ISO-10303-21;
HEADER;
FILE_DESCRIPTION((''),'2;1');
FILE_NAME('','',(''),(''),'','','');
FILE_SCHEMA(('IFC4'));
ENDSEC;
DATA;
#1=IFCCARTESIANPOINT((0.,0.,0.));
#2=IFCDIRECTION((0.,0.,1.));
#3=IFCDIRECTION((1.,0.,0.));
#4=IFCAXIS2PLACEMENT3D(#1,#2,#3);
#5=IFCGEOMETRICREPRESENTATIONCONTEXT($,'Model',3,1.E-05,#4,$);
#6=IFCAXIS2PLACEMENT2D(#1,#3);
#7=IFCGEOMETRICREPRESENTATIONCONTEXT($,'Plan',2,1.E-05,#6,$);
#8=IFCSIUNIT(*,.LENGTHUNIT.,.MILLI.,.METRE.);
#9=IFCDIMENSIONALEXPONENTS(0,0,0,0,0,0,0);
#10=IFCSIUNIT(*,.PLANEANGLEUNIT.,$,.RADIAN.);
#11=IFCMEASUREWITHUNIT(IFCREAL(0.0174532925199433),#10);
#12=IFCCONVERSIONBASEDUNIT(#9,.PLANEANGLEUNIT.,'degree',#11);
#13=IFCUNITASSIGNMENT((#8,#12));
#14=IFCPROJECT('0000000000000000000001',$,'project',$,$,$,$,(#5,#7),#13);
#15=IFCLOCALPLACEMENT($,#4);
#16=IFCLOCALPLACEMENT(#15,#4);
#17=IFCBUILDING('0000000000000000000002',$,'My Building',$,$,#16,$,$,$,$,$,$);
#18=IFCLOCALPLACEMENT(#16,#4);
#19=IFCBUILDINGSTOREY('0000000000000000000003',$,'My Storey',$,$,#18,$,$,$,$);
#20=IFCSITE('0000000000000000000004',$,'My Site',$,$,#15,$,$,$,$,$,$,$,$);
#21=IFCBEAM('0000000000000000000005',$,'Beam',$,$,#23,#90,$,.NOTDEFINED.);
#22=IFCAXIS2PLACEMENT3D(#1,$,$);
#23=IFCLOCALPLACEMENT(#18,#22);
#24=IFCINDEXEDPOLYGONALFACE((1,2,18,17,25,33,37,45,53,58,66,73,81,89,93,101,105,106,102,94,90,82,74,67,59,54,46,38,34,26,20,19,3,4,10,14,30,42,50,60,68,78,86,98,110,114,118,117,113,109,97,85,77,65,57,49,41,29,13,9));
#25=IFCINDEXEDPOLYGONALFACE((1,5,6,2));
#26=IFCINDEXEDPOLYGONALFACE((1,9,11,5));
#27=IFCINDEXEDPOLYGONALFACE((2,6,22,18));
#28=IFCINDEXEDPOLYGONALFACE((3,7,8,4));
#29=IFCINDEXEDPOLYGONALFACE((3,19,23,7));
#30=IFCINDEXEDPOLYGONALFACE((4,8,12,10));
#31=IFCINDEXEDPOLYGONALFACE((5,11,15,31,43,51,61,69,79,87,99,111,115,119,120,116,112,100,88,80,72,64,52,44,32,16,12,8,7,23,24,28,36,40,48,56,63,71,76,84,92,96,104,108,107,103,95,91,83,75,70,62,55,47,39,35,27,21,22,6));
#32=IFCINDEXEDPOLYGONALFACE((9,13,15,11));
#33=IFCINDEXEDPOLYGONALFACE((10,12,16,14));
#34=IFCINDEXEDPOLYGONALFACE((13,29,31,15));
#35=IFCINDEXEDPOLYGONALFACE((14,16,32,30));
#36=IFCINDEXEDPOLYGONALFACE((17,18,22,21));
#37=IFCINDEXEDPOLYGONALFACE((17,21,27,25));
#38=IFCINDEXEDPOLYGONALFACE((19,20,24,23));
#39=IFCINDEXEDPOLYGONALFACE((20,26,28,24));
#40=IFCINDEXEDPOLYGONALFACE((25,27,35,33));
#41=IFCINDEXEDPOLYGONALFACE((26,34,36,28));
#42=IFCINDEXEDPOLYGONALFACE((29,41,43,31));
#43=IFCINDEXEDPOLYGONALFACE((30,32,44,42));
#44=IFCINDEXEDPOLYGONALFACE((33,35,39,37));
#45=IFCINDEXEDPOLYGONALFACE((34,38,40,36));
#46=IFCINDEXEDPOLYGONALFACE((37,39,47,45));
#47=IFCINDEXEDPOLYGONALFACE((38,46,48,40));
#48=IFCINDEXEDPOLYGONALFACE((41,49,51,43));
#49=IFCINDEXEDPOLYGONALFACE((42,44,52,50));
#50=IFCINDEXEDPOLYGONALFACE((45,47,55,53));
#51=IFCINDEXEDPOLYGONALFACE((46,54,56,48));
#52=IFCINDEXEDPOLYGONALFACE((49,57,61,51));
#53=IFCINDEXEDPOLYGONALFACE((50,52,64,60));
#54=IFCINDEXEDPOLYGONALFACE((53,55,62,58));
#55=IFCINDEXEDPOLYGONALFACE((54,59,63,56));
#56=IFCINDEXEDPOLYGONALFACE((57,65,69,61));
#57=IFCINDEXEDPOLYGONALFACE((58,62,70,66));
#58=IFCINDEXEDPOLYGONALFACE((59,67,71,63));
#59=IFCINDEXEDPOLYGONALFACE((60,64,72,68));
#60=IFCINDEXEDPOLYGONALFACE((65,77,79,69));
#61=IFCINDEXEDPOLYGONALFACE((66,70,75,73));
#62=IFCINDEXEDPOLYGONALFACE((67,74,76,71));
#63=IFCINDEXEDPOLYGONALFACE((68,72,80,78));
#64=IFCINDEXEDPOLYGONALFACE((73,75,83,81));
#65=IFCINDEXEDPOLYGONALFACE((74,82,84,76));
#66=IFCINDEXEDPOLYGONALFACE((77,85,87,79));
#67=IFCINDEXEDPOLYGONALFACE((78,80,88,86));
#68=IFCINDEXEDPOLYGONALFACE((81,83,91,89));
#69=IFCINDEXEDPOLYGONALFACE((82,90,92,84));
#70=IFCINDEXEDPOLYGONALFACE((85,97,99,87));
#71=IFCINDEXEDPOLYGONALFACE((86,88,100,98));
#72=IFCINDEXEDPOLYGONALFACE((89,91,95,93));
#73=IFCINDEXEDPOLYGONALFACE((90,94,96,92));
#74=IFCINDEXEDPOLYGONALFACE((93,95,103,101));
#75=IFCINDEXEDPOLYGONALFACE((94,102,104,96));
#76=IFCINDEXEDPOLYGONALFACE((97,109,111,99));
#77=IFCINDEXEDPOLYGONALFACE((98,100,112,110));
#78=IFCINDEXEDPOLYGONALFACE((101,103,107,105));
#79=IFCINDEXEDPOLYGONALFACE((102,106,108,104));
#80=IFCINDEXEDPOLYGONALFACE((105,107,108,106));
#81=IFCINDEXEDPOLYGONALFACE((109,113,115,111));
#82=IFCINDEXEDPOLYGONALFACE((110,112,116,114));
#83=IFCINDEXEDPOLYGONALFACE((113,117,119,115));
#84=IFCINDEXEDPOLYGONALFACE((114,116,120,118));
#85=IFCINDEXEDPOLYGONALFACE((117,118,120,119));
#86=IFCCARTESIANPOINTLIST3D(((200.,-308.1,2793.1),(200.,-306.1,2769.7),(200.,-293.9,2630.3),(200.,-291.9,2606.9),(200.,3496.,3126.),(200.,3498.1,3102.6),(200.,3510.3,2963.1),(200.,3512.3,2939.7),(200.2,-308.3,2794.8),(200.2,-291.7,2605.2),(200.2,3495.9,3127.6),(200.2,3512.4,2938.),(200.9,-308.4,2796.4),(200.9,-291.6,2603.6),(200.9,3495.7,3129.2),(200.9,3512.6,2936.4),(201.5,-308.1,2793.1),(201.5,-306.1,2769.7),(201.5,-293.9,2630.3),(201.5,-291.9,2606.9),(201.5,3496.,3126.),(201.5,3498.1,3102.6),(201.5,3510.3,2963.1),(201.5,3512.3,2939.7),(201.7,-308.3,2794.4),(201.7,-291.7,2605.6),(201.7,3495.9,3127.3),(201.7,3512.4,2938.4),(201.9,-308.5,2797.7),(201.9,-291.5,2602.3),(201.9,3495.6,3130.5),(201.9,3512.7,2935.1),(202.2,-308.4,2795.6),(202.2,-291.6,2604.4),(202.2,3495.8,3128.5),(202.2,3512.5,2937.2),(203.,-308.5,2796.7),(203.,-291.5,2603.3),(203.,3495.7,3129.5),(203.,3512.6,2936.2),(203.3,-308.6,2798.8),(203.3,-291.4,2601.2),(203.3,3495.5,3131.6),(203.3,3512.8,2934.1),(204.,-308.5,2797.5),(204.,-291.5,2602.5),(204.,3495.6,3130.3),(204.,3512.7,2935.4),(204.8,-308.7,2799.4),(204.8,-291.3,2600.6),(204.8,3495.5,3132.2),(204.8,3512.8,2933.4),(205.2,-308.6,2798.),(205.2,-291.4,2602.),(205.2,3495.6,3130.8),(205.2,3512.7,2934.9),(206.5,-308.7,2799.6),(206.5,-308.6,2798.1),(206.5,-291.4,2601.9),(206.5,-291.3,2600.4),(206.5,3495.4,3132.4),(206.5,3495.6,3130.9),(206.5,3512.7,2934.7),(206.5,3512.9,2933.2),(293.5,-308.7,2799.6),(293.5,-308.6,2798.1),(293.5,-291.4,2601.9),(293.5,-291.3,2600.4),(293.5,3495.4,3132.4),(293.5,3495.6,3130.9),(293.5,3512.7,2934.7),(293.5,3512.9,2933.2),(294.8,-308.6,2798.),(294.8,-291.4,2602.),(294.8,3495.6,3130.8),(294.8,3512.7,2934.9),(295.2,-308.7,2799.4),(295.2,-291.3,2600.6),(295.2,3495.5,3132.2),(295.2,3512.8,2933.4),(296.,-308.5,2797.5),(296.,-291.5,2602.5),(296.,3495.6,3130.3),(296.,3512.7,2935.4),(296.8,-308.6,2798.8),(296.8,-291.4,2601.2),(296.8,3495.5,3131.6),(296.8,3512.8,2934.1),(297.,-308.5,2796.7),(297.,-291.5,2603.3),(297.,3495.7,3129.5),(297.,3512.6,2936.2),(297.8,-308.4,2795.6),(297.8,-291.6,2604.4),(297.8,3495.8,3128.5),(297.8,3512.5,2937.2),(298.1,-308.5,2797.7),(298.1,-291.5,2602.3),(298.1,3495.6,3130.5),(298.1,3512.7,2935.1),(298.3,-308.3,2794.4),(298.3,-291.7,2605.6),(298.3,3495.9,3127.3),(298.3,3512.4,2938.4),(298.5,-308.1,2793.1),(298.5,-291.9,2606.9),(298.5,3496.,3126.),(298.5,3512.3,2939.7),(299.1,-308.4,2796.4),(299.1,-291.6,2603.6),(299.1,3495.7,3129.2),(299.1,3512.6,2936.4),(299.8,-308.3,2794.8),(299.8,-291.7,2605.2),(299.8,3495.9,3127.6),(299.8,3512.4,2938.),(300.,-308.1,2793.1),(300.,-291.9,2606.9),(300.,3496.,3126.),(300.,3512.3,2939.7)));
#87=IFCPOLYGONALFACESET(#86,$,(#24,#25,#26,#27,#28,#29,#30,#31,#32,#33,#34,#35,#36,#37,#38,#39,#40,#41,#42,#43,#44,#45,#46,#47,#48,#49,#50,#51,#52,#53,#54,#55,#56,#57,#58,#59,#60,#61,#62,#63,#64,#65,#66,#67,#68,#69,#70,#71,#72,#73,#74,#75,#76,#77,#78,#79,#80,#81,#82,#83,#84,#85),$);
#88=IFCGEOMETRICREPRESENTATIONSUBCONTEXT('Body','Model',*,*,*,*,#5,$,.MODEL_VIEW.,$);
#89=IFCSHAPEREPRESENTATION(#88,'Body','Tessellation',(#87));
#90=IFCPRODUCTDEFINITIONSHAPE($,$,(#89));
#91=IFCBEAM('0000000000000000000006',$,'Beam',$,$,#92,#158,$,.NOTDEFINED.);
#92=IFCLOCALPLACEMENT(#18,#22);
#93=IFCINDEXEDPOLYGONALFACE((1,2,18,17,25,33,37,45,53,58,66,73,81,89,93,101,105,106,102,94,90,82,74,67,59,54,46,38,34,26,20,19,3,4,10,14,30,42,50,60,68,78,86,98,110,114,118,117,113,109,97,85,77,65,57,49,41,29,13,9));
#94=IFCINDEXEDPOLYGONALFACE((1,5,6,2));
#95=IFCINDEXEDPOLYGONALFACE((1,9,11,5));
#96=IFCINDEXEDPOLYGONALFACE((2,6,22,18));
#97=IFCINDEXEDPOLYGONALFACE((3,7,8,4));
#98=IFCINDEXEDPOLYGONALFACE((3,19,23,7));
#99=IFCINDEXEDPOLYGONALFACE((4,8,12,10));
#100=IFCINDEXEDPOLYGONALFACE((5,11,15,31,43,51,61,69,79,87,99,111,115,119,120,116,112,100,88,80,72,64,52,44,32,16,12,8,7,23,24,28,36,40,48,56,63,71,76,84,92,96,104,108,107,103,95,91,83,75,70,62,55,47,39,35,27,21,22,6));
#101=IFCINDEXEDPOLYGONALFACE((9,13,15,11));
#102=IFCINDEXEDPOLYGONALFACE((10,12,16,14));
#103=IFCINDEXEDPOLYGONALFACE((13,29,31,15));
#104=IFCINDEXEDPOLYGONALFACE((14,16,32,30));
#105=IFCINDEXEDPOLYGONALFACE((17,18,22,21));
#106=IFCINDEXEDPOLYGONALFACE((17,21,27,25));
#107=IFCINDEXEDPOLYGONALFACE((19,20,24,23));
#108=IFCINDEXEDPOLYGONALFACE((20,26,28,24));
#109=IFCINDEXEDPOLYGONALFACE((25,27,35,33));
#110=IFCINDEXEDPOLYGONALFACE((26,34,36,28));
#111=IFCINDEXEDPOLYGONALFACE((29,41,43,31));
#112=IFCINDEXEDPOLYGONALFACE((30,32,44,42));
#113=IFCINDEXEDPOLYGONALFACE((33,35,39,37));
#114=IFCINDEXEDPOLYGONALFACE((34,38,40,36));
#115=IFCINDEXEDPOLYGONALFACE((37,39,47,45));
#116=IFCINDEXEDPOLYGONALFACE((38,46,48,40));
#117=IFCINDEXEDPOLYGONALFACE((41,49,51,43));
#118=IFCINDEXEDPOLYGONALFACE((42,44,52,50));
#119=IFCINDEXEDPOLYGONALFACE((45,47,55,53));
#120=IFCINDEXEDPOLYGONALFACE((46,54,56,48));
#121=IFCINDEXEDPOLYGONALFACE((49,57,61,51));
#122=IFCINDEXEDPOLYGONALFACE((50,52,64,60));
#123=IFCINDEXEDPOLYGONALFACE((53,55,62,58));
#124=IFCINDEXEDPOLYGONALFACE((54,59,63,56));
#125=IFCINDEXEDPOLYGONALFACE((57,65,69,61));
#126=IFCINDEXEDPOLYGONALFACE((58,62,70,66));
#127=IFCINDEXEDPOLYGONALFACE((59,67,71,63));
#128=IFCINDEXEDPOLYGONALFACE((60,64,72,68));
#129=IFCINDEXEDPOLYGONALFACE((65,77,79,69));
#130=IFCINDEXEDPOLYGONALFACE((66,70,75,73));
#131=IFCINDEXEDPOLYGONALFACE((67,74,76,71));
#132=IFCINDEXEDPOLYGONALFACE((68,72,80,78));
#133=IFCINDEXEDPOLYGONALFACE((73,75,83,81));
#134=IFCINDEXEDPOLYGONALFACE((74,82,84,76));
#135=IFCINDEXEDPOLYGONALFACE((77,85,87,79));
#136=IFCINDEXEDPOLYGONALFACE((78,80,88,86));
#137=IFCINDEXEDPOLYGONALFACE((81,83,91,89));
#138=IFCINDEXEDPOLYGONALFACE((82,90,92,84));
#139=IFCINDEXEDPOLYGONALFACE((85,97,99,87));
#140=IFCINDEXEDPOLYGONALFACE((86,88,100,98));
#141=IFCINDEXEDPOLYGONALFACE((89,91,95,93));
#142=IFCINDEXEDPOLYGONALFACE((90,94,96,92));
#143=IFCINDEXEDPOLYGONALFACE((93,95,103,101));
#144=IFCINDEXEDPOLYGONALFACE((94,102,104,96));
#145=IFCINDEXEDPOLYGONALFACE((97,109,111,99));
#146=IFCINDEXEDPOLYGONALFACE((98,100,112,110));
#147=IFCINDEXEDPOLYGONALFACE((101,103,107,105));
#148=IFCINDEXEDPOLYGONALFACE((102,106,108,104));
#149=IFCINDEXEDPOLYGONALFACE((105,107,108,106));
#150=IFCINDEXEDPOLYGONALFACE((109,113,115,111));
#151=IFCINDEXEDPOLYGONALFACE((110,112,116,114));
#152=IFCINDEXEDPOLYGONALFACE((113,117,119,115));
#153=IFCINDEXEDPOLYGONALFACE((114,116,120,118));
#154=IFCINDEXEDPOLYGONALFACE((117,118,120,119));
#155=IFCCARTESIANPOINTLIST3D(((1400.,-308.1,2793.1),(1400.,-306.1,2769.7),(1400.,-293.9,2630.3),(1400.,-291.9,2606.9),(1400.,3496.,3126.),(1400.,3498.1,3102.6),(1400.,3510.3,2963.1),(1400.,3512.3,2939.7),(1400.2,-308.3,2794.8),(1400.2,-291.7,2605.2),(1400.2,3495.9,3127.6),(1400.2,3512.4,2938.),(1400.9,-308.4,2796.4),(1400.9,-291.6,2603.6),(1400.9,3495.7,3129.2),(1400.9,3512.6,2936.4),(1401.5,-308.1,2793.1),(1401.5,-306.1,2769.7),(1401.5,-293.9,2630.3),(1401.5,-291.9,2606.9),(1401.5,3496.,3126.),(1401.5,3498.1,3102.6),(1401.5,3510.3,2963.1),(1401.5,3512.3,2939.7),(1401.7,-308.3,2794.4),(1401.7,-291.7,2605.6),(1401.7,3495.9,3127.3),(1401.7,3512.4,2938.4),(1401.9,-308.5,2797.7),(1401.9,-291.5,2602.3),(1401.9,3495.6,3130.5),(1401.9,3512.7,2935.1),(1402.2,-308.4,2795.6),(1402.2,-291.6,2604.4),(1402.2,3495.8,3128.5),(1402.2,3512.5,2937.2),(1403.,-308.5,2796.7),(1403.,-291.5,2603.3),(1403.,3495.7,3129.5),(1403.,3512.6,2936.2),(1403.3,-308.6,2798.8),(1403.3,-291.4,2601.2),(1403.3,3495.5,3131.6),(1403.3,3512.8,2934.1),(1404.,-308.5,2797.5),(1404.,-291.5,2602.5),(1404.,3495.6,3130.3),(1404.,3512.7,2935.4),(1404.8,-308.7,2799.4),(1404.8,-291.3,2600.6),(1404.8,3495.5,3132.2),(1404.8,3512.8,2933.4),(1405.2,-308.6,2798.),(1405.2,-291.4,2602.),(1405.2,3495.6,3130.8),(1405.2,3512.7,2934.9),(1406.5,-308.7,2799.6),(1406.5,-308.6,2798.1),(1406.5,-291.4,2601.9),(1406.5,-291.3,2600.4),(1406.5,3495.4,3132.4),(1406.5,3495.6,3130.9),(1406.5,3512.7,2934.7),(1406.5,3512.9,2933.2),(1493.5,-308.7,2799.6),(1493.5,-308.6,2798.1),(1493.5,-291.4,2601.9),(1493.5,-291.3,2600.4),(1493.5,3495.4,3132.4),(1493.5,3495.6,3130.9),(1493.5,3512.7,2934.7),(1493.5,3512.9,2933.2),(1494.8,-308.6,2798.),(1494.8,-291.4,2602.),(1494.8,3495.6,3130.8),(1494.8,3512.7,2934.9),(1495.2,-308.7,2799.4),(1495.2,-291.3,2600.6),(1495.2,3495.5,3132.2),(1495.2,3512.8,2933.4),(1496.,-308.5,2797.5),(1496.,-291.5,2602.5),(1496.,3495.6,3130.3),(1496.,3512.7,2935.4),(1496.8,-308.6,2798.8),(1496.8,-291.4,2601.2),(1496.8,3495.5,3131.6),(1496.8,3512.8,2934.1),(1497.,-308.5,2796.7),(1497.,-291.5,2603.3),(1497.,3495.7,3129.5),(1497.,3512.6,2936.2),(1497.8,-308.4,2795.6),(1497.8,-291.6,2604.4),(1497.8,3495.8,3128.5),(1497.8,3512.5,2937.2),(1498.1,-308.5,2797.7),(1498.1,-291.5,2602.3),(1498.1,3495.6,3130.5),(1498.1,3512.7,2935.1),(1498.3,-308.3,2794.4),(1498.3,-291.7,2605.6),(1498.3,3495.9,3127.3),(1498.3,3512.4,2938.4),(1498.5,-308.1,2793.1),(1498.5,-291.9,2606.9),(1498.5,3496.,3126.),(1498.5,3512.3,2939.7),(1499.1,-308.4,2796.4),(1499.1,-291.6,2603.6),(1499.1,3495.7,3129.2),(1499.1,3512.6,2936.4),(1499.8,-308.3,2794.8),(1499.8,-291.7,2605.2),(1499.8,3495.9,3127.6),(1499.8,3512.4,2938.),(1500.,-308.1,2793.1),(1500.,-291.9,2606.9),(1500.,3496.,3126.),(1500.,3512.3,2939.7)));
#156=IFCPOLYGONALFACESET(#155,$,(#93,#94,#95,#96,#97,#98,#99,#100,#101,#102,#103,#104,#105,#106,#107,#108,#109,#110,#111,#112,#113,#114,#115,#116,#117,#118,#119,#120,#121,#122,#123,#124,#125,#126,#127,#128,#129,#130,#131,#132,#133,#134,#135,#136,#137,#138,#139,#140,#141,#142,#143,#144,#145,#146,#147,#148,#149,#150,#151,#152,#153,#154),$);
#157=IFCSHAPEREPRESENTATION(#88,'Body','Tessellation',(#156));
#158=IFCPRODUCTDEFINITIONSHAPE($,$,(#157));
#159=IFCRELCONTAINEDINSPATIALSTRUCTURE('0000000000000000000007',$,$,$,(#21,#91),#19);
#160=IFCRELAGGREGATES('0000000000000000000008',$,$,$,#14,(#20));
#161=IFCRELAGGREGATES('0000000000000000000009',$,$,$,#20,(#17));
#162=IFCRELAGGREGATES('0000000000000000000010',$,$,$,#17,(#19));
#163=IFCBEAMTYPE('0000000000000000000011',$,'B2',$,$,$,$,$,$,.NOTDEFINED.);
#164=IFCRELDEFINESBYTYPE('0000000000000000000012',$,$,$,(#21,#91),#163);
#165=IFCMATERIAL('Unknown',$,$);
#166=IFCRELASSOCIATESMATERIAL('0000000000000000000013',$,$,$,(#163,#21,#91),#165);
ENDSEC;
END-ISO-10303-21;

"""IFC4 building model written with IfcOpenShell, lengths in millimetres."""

from ifc_helpers import new_model, entity, si_unit, converted_unit, frame, frame_2d, origin_with_axes, place, context, subcontext, project, spatial, c_section, extrude, material, material_profile, profile_set, profile_usage, type_object, element, save


model = new_model("IFC4")

# Units and contexts
model_context = context("Model", 3, precision=1e-05, world=origin_with_axes())
plan_context = context("Plan", 2, precision=1e-05, world=frame_2d((0.0, 0.0, 0.0), x_axis=(1.0, 0.0, 0.0)))
body_context = subcontext(model_context, "Body", "Model", "MODEL_VIEW")
ifc_project = project(units=[si_unit("LENGTHUNIT", "METRE", prefix="MILLI"), converted_unit("PLANEANGLEUNIT", "degree", entity("IfcReal", 0.0174532925199433), si_unit("PLANEANGLEUNIT", "RADIAN"), dimensions=[0, 0, 0, 0, 0, 0, 0])], contexts=[model_context, plan_context])

# Site, building, storey
site_placement = place(None, origin_with_axes())
site = spatial("IfcSite", under=ifc_project, at=site_placement, Name="My Site")
building_placement = place(site_placement, origin_with_axes())
building = spatial("IfcBuilding", under=site, at=building_placement, Name="My Building")
storey_placement = place(building_placement, origin_with_axes())
storey = spatial("IfcBuildingStorey", under=building, at=storey_placement, Name="My Storey")

# Shared definitions
ifc_material = material(Name="Unknown")

# Beams
ifc_material_profile_1 = material_profile(ifc_material, c_section(Depth=200.0, Width=100.0, WallThickness=1.5, Girth=30.0, InternalFilletRadius=5.0))
ifc_profile_set_1 = profile_set([ifc_material_profile_1])
ifc_profile_usage_1 = profile_usage(ifc_profile_set_1, cardinal=5)
beam_type_1 = type_object("IfcBeamType", Name="B2", PredefinedType="NOTDEFINED", material=ifc_profile_set_1)
beam_1_placement = place(storey_placement, frame((250.0, -300.0, 2700.0), z_axis=(0.0, 0.996195, 0.087156), x_axis=(-1.0, 0.0, 0.0)))
element("IfcBeam", 1, at=beam_1_placement, inside=storey, type_object=beam_type_1, material=ifc_profile_usage_1, Name="Beam", PredefinedType="NOTDEFINED", context=body_context, shape_type="SweptSolid", body=[
    extrude(c_section(Depth=200.0, Width=100.0, WallThickness=1.5, Girth=30.0, InternalFilletRadius=5.0), origin_with_axes(), (0.0, 0.0, 1.0), 3818.7),
])
ifc_profile_usage_2 = profile_usage(ifc_profile_set_1, cardinal=5)
beam_2_placement = place(storey_placement, frame((1450.0, -300.0, 2700.0), z_axis=(0.0, 0.996195, 0.087156), x_axis=(-1.0, 0.0, 0.0)))
element("IfcBeam", 2, at=beam_2_placement, inside=storey, type_object=beam_type_1, material=ifc_profile_usage_2, Name="Beam", PredefinedType="NOTDEFINED", context=body_context, shape_type="SweptSolid", body=[
    extrude(c_section(Depth=200.0, Width=100.0, WallThickness=1.5, Girth=30.0, InternalFilletRadius=5.0), origin_with_axes(), (0.0, 0.0, 1.0), 3818.7),
])

save(model, "model.ifc")
